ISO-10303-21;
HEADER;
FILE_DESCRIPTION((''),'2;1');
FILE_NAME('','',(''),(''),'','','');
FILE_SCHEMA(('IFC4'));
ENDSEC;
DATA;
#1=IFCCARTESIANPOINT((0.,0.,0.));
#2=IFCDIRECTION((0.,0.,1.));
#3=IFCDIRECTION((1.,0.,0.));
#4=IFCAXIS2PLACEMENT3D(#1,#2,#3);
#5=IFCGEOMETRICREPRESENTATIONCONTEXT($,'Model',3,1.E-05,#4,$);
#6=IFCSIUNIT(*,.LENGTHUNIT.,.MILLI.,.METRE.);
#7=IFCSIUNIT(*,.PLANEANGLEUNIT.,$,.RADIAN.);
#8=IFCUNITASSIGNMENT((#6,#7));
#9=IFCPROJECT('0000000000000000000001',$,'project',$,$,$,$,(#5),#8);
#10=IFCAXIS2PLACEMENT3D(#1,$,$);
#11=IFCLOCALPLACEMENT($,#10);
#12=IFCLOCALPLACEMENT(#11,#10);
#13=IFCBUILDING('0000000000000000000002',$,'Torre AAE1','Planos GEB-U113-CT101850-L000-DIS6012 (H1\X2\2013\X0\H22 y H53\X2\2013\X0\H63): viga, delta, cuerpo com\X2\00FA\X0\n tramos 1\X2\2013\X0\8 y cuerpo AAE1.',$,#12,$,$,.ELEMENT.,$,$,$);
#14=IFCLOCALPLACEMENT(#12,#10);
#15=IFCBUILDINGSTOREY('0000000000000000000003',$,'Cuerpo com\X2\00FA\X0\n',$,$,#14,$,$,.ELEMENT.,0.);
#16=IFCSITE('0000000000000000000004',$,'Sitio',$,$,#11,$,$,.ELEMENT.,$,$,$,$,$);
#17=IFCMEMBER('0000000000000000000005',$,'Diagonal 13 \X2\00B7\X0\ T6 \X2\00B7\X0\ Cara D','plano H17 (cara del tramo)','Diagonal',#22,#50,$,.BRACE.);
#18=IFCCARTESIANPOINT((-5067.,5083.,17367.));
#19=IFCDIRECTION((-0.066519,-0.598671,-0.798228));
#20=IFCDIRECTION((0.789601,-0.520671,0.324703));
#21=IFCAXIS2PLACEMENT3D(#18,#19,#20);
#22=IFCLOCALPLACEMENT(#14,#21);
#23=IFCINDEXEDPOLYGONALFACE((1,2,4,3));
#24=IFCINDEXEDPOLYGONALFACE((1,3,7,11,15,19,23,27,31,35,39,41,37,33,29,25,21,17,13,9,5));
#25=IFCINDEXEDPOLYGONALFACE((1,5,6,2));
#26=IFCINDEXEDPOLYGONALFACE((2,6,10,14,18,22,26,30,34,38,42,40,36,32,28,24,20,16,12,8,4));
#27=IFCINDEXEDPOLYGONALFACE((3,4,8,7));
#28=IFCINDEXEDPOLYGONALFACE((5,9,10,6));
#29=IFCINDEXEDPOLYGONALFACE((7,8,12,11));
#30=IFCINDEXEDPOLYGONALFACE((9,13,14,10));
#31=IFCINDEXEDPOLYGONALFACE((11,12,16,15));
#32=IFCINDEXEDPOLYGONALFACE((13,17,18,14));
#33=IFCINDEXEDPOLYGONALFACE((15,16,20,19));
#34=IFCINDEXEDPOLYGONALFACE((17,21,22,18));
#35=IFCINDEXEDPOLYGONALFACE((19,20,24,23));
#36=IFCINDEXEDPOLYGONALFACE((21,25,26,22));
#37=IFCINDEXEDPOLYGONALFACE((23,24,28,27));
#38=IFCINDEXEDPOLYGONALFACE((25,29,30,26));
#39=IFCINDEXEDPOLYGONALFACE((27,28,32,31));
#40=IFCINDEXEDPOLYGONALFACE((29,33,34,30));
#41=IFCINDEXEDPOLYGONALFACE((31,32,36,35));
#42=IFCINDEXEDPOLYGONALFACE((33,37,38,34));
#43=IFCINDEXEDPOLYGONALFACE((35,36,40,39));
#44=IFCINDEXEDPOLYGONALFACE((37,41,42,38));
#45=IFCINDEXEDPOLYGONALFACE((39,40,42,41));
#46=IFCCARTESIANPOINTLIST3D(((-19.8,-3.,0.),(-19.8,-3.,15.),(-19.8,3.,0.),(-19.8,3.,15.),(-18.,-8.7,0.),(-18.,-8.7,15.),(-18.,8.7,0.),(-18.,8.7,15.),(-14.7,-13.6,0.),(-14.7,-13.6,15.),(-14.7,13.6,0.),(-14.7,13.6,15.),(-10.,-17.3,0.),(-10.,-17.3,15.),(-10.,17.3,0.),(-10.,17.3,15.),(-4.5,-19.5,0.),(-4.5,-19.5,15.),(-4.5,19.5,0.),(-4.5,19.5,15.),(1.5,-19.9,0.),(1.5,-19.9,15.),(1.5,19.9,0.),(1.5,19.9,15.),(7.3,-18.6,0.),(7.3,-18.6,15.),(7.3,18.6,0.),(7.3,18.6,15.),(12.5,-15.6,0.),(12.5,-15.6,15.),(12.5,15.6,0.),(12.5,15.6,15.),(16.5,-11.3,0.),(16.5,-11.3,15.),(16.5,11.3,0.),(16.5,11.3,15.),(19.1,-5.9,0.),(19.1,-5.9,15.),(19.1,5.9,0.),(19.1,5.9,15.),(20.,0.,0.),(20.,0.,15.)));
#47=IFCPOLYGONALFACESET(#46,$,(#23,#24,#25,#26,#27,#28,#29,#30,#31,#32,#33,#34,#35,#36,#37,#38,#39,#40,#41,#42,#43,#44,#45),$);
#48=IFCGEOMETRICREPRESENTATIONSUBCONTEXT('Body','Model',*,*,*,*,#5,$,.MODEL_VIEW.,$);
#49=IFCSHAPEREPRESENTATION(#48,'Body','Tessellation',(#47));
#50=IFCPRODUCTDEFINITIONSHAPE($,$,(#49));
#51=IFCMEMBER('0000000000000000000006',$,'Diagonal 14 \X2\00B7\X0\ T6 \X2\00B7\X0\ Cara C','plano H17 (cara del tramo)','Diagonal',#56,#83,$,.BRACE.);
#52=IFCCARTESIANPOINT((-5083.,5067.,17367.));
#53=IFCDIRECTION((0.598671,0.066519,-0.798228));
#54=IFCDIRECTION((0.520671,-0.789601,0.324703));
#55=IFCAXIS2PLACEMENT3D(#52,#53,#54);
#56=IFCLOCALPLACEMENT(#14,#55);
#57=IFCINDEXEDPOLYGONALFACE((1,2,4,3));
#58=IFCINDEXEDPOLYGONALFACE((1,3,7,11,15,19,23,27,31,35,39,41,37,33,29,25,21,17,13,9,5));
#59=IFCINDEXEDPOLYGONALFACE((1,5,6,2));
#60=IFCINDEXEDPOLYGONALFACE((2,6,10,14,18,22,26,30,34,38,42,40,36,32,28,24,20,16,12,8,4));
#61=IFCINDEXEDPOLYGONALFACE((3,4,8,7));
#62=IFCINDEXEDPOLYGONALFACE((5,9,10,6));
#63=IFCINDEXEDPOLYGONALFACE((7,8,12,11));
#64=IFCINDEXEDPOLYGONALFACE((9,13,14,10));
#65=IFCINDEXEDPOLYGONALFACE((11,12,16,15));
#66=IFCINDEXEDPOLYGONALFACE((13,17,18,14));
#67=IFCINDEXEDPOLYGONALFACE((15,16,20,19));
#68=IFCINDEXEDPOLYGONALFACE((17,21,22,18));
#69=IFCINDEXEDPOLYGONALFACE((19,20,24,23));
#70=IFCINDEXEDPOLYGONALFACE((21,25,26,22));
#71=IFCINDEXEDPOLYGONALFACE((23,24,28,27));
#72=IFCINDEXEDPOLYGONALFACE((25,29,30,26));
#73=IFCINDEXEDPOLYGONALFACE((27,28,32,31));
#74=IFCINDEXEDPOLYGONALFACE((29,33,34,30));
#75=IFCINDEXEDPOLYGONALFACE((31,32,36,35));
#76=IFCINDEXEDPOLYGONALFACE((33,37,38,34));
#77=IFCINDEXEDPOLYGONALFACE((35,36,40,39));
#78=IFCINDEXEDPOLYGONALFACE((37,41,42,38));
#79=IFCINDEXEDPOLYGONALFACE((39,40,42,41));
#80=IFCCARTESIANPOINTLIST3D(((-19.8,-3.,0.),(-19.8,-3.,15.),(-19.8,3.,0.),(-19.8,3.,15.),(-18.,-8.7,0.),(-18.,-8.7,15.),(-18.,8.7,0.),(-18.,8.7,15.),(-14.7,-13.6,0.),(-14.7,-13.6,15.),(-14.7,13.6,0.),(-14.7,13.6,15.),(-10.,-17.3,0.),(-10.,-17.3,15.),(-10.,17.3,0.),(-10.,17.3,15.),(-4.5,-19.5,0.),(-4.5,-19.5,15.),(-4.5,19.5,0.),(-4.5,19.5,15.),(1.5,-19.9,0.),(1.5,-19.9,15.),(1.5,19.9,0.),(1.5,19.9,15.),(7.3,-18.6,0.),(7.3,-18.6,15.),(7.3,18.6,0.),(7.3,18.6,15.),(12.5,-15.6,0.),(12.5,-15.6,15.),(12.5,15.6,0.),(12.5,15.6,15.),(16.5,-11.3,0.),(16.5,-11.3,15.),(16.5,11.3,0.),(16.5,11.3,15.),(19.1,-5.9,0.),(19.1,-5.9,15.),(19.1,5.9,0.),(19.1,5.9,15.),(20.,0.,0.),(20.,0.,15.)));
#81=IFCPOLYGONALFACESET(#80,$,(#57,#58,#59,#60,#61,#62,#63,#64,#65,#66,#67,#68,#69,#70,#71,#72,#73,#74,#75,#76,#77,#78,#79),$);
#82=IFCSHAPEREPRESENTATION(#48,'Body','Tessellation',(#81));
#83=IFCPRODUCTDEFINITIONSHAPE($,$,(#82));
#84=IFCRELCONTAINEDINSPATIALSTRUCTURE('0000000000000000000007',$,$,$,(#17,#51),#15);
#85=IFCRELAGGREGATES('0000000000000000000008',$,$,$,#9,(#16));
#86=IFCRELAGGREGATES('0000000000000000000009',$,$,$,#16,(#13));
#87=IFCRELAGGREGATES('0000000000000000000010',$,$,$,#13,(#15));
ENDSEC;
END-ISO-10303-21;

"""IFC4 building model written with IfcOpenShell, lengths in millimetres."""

from ifc_helpers import new_model, si_unit, frame, origin, origin_with_axes, place, context, subcontext, project, spatial, circle, extrude, element, save


model = new_model("IFC4")

# Units and contexts
model_context = context("Model", 3, precision=1e-05, world=origin_with_axes())
body_context = subcontext(model_context, "Body", "Model", "MODEL_VIEW")
ifc_project = project(units=[si_unit("LENGTHUNIT", "METRE", prefix="MILLI"), si_unit("PLANEANGLEUNIT", "RADIAN")], contexts=[model_context])

# Site, building, storey
site_placement = place(None, origin())
site = spatial("IfcSite", under=ifc_project, at=site_placement, Name="Sitio", CompositionType="ELEMENT")
building_placement = place(site_placement, origin())
building = spatial("IfcBuilding", under=site, at=building_placement, Name="Torre AAE1", Description="Planos GEB-U113-CT101850-L000-DIS6012 (H1–H22 y H53–H63): viga, delta, cuerpo común tramos 1–8 y cuerpo AAE1.", CompositionType="ELEMENT")
storey_placement = place(building_placement, origin())
storey = spatial("IfcBuildingStorey", under=building, at=storey_placement, Name="Cuerpo común", CompositionType="ELEMENT", Elevation=0.0)

# Members
for number, where, z_axis, x_axis, name in (
    (1, (-5067.0, 5083.0, 17367.0), (-0.066519, -0.598671, -0.798228), (0.789601, -0.520671, 0.324703), "Diagonal 13 · T6 · Cara D"),
    (2, (-5083.0, 5067.0, 17367.0), (0.598671, 0.066519, -0.798228), (0.520671, -0.789601, 0.324703), "Diagonal 14 · T6 · Cara C"),
):
    element("IfcMember", number, at=place(storey_placement, frame(where, z_axis=z_axis, x_axis=x_axis)), inside=storey, Name=name, Description="plano H17 (cara del tramo)", ObjectType="Diagonal", PredefinedType="BRACE", context=body_context, shape_type="SweptSolid", body=[
        extrude(circle(Radius=20.0), None, (0.0, 0.0, 1.0), 15.0),
    ])

save(model, "model.ifc")
